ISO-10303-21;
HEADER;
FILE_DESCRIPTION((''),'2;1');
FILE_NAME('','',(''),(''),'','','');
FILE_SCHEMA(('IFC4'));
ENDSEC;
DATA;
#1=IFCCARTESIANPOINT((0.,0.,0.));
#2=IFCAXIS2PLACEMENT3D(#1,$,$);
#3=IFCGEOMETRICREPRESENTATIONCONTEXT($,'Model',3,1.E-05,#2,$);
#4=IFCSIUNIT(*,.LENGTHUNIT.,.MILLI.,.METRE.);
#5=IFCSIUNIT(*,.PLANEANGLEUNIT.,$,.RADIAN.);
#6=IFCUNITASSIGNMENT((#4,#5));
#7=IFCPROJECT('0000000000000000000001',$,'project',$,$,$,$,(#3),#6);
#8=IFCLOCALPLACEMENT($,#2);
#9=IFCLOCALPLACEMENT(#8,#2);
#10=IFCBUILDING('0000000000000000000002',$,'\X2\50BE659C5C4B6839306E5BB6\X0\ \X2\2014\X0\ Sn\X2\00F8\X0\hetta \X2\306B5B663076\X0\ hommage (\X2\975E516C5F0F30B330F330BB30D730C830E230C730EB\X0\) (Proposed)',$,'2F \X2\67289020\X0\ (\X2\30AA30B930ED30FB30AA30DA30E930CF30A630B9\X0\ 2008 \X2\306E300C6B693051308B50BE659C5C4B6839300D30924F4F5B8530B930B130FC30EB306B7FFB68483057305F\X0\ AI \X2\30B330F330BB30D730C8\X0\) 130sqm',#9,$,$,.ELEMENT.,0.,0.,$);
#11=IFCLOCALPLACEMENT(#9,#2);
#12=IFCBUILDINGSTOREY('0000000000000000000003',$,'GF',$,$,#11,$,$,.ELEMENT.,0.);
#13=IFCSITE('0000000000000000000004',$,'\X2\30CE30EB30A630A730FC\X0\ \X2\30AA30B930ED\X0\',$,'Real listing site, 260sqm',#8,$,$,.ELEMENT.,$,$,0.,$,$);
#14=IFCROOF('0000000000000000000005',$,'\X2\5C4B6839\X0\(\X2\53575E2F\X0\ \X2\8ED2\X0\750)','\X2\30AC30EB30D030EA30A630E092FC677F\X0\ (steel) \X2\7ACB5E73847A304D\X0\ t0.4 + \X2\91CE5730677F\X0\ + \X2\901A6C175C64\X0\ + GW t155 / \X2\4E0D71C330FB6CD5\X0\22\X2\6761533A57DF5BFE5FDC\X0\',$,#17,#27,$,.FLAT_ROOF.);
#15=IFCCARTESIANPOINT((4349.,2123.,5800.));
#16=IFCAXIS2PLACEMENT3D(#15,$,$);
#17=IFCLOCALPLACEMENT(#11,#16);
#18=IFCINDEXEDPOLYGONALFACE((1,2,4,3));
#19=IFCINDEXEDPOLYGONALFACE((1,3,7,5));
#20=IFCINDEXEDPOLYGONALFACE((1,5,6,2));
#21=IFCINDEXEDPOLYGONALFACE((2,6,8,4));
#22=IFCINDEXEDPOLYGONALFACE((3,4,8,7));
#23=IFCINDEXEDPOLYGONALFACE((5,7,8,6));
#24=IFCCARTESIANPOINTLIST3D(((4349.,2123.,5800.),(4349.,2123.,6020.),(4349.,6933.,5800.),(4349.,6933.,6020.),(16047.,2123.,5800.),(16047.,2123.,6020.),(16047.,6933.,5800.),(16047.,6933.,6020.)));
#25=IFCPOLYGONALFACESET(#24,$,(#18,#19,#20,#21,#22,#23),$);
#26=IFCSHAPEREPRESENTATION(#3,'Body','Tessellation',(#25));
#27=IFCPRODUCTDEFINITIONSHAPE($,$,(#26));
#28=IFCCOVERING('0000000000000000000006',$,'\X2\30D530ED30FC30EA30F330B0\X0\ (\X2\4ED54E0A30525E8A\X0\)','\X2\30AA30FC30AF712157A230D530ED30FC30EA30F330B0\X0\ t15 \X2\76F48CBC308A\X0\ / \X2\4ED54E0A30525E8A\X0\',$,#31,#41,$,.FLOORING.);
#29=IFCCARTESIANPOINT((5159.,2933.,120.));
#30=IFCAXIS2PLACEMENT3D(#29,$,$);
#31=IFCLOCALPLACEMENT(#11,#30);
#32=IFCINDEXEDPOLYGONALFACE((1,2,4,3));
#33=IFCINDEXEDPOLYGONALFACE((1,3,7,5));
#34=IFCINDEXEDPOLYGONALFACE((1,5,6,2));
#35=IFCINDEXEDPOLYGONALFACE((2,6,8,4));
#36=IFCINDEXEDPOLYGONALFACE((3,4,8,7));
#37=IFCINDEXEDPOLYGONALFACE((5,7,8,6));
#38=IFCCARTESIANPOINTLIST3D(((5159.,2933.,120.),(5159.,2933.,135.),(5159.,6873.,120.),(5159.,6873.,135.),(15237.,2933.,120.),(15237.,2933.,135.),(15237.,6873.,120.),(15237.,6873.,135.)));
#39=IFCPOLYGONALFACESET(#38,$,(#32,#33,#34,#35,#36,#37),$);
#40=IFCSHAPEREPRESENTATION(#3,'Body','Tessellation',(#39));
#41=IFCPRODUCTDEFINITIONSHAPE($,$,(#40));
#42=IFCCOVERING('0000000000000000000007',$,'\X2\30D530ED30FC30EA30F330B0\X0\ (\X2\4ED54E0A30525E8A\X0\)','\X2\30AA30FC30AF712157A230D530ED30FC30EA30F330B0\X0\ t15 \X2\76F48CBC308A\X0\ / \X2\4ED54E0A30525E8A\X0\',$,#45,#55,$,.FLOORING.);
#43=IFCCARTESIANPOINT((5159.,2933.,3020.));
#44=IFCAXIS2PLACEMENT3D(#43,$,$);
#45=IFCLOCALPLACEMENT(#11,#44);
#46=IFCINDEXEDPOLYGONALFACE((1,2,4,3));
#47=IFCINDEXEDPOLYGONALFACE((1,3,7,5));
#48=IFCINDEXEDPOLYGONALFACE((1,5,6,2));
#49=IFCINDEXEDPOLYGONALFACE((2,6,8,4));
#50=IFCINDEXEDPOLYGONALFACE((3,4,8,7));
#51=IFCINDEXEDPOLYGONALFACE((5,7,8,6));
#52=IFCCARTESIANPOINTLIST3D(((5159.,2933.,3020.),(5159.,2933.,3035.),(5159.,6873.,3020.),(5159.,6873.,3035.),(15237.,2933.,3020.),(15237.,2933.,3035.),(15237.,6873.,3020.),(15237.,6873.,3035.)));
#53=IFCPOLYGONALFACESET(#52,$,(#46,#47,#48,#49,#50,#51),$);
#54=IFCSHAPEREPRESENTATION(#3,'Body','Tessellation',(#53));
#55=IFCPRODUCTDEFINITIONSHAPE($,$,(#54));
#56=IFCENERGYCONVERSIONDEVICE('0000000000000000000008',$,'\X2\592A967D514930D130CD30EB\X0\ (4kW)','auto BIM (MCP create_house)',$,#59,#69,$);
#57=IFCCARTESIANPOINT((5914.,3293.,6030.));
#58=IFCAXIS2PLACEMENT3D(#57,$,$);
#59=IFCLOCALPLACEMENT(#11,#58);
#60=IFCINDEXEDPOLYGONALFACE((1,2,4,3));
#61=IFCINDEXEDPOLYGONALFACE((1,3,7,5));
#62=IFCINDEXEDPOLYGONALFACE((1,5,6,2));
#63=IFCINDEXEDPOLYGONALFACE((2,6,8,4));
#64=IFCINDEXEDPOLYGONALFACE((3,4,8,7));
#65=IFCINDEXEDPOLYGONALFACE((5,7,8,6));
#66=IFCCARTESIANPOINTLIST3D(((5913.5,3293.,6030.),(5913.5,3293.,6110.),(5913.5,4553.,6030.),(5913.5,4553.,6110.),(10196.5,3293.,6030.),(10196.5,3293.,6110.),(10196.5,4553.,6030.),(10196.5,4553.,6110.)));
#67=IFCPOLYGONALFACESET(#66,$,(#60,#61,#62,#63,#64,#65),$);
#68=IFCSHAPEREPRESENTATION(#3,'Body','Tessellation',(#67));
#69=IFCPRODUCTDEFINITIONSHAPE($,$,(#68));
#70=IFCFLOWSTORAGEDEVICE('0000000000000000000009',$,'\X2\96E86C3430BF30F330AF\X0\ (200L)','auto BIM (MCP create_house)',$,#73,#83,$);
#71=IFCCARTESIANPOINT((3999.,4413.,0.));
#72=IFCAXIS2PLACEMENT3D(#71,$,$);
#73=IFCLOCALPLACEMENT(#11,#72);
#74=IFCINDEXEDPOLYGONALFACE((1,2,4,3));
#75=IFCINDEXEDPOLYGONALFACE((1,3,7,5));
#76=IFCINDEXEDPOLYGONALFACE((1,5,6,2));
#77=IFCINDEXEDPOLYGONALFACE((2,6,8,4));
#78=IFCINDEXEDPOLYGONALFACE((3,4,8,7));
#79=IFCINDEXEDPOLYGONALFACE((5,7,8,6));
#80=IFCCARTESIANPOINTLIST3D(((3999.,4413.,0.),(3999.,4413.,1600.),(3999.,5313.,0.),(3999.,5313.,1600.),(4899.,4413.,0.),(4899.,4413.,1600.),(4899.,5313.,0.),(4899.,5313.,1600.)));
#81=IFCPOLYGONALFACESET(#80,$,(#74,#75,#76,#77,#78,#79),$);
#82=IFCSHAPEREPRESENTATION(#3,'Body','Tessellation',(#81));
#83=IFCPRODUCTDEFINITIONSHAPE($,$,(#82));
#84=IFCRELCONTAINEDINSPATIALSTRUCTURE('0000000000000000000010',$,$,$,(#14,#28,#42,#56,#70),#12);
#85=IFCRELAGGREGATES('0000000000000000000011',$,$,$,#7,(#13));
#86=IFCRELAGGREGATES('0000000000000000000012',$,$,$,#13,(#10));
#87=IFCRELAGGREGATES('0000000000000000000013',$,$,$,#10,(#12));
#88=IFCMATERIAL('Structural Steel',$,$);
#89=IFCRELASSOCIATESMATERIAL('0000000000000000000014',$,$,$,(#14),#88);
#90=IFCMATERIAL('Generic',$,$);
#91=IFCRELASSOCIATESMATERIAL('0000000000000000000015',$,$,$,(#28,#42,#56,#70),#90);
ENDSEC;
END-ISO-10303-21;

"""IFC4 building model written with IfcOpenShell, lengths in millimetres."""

from ifc_helpers import new_model, si_unit, frame, frame_2d, origin, place, context, project, spatial, rectangle, extrude, material, element, save


model = new_model("IFC4")

# Units and contexts
model_context = context("Model", 3, precision=1e-05, world=origin())
ifc_project = project(units=[si_unit("LENGTHUNIT", "METRE", prefix="MILLI"), si_unit("PLANEANGLEUNIT", "RADIAN")], contexts=[model_context])

# Site, building, storey
site_placement = place(None, origin())
site = spatial("IfcSite", under=ifc_project, at=site_placement, Name="ノルウェー オスロ", ObjectType="Real listing site, 260sqm", CompositionType="ELEMENT", RefElevation=0.0)
building_placement = place(site_placement, origin())
building = spatial("IfcBuilding", under=site, at=building_placement, Name="傾斜屋根の家 — Snøhetta に学ぶ hommage (非公式コンセプトモデル) (Proposed)", ObjectType="2F 木造 (オスロ・オペラハウス 2008 の「歩ける傾斜屋根」を住宅スケールに翻案した AI コンセプト) 130sqm", CompositionType="ELEMENT", ElevationOfRefHeight=0.0, ElevationOfTerrain=0.0)
storey_placement = place(building_placement, origin())
storey = spatial("IfcBuildingStorey", under=building, at=storey_placement, Name="GF", CompositionType="ELEMENT", Elevation=0.0)

# Roof
ifc_material_1 = material(Name="Structural Steel")
for number, where, name in (
    (1, (4349.0, 2123.0, 5800.0), "屋根(南帯 軒750)"),
):
    element("IfcRoof", number, at=place(storey_placement, frame(where)), inside=storey, material=ifc_material_1, Name=name, Description="ガルバリウム鋼板 (steel) 立平葺き t0.4 + 野地板 + 通気層 + GW t155 / 不燃・法22条区域対応", PredefinedType="FLAT_ROOF", context=model_context, shape_type="SweptSolid", body=[
        extrude(rectangle(XDim=11698.0, YDim=4810.0, at=frame_2d((5849.0, 2405.0))), frame((4349.0, 2123.0, 5800.0)), (0.0, 0.0, 1.0), 220.0),
    ])

# Coverings
ifc_material_2 = material(Name="Generic")
covering_1_placement = place(storey_placement, frame((5159.0, 2933.0, 120.0)))
element("IfcCovering", 2, at=covering_1_placement, inside=storey, material=ifc_material_2, Name="フローリング (仕上げ床)", Description="オーク無垢フローリング t15 直貼り / 仕上げ床", PredefinedType="FLOORING", context=model_context, shape_type="SweptSolid", body=[
    extrude(rectangle(XDim=10078.0, YDim=3940.0, at=frame_2d((5039.0, 1970.0))), frame((5159.0, 2933.0, 120.0)), (0.0, 0.0, 1.0), 15.0),
])
covering_2_placement = place(storey_placement, frame((5159.0, 2933.0, 3020.0)))
element("IfcCovering", 3, at=covering_2_placement, inside=storey, material=ifc_material_2, Name="フローリング (仕上げ床)", Description="オーク無垢フローリング t15 直貼り / 仕上げ床", PredefinedType="FLOORING", context=model_context, shape_type="SweptSolid", body=[
    extrude(rectangle(XDim=10078.0, YDim=3940.0, at=frame_2d((5039.0, 1970.0))), frame((5159.0, 2933.0, 3020.0)), (0.0, 0.0, 1.0), 15.0),
])

# Energy conversion device
energy_conversion_device_placement = place(storey_placement, frame((5914.0, 3293.0, 6030.0)))
element("IfcEnergyConversionDevice", 4, at=energy_conversion_device_placement, inside=storey, material=ifc_material_2, Name="太陽光パネル (4kW)", Description="auto BIM (MCP create_house)", context=model_context, shape_type="SweptSolid", body=[
    extrude(rectangle(XDim=4283.0, YDim=1260.0, at=frame_2d((2141.0, 630.0))), frame((5914.0, 3293.0, 6030.0)), (0.0, 0.0, 1.0), 80.0),
])

# Flow storage device
flow_storage_device_placement = place(storey_placement, frame((3999.0, 4413.0, 0.0)))
element("IfcFlowStorageDevice", 5, at=flow_storage_device_placement, inside=storey, material=ifc_material_2, Name="雨水タンク (200L)", Description="auto BIM (MCP create_house)", context=model_context, shape_type="SweptSolid", body=[
    extrude(rectangle(XDim=900.0, YDim=900.0, at=frame_2d((450.0, 450.0))), frame((3999.0, 4413.0, 0.0)), (0.0, 0.0, 1.0), 1600.0),
])

save(model, "model.ifc")
